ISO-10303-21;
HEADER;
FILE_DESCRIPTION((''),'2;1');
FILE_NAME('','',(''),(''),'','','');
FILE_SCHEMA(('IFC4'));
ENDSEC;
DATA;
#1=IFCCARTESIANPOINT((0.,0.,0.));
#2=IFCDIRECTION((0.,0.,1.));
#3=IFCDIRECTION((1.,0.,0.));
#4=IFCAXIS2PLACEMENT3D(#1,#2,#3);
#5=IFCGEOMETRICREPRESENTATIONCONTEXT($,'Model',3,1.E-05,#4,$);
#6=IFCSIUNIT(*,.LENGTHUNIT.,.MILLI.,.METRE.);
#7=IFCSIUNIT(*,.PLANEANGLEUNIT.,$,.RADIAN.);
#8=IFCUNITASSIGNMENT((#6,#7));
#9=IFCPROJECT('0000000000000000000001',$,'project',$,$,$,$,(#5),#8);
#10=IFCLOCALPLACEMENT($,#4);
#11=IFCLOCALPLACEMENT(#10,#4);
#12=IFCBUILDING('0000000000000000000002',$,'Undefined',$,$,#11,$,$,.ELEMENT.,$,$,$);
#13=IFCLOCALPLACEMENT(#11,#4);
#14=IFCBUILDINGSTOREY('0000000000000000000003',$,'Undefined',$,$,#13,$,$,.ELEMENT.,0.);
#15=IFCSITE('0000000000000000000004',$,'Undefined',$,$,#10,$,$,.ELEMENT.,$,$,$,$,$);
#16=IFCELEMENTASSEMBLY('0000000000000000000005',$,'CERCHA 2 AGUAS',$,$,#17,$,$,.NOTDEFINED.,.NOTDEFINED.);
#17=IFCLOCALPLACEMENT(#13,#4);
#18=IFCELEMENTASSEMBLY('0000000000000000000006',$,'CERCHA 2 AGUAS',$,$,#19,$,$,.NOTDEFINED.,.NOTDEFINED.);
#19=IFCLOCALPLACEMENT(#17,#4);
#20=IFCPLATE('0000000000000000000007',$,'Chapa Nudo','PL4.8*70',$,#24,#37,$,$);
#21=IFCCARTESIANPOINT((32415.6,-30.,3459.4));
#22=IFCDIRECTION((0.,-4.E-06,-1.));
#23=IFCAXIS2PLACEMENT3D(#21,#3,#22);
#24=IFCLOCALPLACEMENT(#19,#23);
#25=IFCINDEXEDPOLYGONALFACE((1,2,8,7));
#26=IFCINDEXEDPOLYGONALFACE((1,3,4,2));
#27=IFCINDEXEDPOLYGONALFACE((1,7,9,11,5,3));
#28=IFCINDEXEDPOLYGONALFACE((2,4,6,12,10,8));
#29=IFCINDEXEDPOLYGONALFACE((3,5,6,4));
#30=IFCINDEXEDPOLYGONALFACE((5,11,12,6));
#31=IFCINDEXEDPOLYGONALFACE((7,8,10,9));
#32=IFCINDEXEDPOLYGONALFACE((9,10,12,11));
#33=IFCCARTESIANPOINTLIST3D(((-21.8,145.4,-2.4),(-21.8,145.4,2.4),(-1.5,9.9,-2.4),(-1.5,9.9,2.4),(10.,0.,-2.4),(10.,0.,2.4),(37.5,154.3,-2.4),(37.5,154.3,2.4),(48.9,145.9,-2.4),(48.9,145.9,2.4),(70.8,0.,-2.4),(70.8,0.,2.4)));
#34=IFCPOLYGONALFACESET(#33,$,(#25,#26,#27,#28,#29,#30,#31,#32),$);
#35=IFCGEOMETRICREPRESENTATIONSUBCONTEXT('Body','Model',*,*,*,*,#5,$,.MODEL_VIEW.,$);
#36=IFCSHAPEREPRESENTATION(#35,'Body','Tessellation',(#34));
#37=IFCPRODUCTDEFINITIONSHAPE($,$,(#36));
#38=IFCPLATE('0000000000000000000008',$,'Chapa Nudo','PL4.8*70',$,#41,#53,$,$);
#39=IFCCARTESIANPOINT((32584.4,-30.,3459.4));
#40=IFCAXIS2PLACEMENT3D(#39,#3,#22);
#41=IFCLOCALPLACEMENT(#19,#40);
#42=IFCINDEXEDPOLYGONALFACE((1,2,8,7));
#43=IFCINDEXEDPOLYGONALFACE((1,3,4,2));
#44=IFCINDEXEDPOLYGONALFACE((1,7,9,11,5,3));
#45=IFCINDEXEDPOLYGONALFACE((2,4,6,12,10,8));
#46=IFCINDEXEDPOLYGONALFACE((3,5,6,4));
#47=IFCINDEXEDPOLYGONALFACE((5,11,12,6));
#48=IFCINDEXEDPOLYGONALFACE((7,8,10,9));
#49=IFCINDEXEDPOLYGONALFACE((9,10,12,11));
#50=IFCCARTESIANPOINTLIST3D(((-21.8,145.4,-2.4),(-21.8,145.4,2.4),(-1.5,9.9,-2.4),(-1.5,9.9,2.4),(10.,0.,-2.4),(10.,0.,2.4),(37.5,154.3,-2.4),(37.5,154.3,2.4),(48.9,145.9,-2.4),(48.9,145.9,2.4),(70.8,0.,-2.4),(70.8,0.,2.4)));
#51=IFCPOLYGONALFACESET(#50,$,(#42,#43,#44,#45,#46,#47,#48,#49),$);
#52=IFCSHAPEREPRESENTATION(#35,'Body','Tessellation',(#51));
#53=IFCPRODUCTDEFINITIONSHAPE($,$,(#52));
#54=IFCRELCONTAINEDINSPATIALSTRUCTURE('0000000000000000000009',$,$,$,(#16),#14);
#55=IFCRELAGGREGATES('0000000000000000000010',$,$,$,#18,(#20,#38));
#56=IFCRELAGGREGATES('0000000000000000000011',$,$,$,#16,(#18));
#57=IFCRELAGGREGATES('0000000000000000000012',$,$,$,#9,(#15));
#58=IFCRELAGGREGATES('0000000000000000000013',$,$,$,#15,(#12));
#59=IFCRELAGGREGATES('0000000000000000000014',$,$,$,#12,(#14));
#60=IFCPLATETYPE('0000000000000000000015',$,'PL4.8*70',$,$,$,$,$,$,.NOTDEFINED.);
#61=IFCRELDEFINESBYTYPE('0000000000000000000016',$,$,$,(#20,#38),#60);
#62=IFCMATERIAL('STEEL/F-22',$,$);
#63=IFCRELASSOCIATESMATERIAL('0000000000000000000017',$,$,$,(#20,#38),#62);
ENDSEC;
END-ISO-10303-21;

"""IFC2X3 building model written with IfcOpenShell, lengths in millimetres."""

from ifc_helpers import new_model, si_unit, frame, origin_with_axes, place, context, subcontext, project, spatial, polyline, outline, extrude, material, type_object, element, aggregate, save


model = new_model("IFC2X3")

# Units and contexts
model_context = context("Model", 3, precision=1e-05, world=origin_with_axes())
body_context = subcontext(model_context, "Body", "Model", "MODEL_VIEW")
ifc_project = project(units=[si_unit("LENGTHUNIT", "METRE", prefix="MILLI"), si_unit("PLANEANGLEUNIT", "RADIAN")], contexts=[model_context])

# Site, building, storey
site_placement = place(None, origin_with_axes())
site = spatial("IfcSite", under=ifc_project, at=site_placement, Name="Undefined", CompositionType="ELEMENT")
building_placement = place(site_placement, origin_with_axes())
building = spatial("IfcBuilding", under=site, at=building_placement, Name="Undefined", CompositionType="ELEMENT")
storey_placement = place(building_placement, origin_with_axes())
storey = spatial("IfcBuildingStorey", under=building, at=storey_placement, Name="Undefined", CompositionType="ELEMENT", Elevation=0.0)

# Element assemblies
assembly_1_placement = place(storey_placement, origin_with_axes())
assembly_1 = element("IfcElementAssembly", 1, at=assembly_1_placement, inside=storey, Name="CERCHA 2 AGUAS", AssemblyPlace="NOTDEFINED", PredefinedType="NOTDEFINED")
assembly_2_placement = place(assembly_1_placement, origin_with_axes())
assembly_2 = element("IfcElementAssembly", 2, at=assembly_2_placement, Name="CERCHA 2 AGUAS", AssemblyPlace="NOTDEFINED", PredefinedType="NOTDEFINED")
ifc_material_1 = material(Name="STEEL/F-22")

# Plates
plate_type_1 = type_object("IfcPlateType", Name="PL4.8*70", PredefinedType="NOTDEFINED")
plate_1_placement = place(assembly_2_placement, frame((32415.6, -30.0, 3459.4), z_axis=(1.0, 0.0, 0.0), x_axis=(0.0, -0.000004, -1.0)))
plate_1 = element("IfcPlate", 3, at=plate_1_placement, type_object=plate_type_1, material=ifc_material_1, Name="Chapa Nudo", Description="PL4.8*70", context=body_context, shape_type="SweptSolid", body=[
    extrude(outline(polyline([(-1.5, 9.9), (10.0, 0.0), (70.8, 0.0), (70.8, 0.0), (48.9, 145.9), (37.5, 154.3), (-21.8, 145.4), (-1.5, 9.9)])), frame((0.0, 0.0, -2.4), z_axis=(0.0, 0.0, 1.0), x_axis=(1.0, 0.0, 0.0)), (0.0, 0.0, 1.0), 4.8),
])
plate_2_placement = place(assembly_2_placement, frame((32584.4, -30.0, 3459.4), z_axis=(1.0, 0.0, 0.0), x_axis=(0.0, -0.000004, -1.0)))
plate_2 = element("IfcPlate", 4, at=plate_2_placement, type_object=plate_type_1, material=ifc_material_1, Name="Chapa Nudo", Description="PL4.8*70", context=body_context, shape_type="SweptSolid", body=[
    extrude(outline(polyline([(-1.5, 9.9), (10.0, 0.0), (70.8, 0.0), (70.8, 0.0), (48.9, 145.9), (37.5, 154.3), (-21.8, 145.4), (-1.5, 9.9)])), frame((0.0, 0.0, -2.4), z_axis=(0.0, 0.0, 1.0), x_axis=(1.0, 0.0, 0.0)), (0.0, 0.0, 1.0), 4.8),
])

aggregate(assembly_2, [plate_1, plate_2])
aggregate(assembly_1, [assembly_2])

save(model, "model.ifc")
